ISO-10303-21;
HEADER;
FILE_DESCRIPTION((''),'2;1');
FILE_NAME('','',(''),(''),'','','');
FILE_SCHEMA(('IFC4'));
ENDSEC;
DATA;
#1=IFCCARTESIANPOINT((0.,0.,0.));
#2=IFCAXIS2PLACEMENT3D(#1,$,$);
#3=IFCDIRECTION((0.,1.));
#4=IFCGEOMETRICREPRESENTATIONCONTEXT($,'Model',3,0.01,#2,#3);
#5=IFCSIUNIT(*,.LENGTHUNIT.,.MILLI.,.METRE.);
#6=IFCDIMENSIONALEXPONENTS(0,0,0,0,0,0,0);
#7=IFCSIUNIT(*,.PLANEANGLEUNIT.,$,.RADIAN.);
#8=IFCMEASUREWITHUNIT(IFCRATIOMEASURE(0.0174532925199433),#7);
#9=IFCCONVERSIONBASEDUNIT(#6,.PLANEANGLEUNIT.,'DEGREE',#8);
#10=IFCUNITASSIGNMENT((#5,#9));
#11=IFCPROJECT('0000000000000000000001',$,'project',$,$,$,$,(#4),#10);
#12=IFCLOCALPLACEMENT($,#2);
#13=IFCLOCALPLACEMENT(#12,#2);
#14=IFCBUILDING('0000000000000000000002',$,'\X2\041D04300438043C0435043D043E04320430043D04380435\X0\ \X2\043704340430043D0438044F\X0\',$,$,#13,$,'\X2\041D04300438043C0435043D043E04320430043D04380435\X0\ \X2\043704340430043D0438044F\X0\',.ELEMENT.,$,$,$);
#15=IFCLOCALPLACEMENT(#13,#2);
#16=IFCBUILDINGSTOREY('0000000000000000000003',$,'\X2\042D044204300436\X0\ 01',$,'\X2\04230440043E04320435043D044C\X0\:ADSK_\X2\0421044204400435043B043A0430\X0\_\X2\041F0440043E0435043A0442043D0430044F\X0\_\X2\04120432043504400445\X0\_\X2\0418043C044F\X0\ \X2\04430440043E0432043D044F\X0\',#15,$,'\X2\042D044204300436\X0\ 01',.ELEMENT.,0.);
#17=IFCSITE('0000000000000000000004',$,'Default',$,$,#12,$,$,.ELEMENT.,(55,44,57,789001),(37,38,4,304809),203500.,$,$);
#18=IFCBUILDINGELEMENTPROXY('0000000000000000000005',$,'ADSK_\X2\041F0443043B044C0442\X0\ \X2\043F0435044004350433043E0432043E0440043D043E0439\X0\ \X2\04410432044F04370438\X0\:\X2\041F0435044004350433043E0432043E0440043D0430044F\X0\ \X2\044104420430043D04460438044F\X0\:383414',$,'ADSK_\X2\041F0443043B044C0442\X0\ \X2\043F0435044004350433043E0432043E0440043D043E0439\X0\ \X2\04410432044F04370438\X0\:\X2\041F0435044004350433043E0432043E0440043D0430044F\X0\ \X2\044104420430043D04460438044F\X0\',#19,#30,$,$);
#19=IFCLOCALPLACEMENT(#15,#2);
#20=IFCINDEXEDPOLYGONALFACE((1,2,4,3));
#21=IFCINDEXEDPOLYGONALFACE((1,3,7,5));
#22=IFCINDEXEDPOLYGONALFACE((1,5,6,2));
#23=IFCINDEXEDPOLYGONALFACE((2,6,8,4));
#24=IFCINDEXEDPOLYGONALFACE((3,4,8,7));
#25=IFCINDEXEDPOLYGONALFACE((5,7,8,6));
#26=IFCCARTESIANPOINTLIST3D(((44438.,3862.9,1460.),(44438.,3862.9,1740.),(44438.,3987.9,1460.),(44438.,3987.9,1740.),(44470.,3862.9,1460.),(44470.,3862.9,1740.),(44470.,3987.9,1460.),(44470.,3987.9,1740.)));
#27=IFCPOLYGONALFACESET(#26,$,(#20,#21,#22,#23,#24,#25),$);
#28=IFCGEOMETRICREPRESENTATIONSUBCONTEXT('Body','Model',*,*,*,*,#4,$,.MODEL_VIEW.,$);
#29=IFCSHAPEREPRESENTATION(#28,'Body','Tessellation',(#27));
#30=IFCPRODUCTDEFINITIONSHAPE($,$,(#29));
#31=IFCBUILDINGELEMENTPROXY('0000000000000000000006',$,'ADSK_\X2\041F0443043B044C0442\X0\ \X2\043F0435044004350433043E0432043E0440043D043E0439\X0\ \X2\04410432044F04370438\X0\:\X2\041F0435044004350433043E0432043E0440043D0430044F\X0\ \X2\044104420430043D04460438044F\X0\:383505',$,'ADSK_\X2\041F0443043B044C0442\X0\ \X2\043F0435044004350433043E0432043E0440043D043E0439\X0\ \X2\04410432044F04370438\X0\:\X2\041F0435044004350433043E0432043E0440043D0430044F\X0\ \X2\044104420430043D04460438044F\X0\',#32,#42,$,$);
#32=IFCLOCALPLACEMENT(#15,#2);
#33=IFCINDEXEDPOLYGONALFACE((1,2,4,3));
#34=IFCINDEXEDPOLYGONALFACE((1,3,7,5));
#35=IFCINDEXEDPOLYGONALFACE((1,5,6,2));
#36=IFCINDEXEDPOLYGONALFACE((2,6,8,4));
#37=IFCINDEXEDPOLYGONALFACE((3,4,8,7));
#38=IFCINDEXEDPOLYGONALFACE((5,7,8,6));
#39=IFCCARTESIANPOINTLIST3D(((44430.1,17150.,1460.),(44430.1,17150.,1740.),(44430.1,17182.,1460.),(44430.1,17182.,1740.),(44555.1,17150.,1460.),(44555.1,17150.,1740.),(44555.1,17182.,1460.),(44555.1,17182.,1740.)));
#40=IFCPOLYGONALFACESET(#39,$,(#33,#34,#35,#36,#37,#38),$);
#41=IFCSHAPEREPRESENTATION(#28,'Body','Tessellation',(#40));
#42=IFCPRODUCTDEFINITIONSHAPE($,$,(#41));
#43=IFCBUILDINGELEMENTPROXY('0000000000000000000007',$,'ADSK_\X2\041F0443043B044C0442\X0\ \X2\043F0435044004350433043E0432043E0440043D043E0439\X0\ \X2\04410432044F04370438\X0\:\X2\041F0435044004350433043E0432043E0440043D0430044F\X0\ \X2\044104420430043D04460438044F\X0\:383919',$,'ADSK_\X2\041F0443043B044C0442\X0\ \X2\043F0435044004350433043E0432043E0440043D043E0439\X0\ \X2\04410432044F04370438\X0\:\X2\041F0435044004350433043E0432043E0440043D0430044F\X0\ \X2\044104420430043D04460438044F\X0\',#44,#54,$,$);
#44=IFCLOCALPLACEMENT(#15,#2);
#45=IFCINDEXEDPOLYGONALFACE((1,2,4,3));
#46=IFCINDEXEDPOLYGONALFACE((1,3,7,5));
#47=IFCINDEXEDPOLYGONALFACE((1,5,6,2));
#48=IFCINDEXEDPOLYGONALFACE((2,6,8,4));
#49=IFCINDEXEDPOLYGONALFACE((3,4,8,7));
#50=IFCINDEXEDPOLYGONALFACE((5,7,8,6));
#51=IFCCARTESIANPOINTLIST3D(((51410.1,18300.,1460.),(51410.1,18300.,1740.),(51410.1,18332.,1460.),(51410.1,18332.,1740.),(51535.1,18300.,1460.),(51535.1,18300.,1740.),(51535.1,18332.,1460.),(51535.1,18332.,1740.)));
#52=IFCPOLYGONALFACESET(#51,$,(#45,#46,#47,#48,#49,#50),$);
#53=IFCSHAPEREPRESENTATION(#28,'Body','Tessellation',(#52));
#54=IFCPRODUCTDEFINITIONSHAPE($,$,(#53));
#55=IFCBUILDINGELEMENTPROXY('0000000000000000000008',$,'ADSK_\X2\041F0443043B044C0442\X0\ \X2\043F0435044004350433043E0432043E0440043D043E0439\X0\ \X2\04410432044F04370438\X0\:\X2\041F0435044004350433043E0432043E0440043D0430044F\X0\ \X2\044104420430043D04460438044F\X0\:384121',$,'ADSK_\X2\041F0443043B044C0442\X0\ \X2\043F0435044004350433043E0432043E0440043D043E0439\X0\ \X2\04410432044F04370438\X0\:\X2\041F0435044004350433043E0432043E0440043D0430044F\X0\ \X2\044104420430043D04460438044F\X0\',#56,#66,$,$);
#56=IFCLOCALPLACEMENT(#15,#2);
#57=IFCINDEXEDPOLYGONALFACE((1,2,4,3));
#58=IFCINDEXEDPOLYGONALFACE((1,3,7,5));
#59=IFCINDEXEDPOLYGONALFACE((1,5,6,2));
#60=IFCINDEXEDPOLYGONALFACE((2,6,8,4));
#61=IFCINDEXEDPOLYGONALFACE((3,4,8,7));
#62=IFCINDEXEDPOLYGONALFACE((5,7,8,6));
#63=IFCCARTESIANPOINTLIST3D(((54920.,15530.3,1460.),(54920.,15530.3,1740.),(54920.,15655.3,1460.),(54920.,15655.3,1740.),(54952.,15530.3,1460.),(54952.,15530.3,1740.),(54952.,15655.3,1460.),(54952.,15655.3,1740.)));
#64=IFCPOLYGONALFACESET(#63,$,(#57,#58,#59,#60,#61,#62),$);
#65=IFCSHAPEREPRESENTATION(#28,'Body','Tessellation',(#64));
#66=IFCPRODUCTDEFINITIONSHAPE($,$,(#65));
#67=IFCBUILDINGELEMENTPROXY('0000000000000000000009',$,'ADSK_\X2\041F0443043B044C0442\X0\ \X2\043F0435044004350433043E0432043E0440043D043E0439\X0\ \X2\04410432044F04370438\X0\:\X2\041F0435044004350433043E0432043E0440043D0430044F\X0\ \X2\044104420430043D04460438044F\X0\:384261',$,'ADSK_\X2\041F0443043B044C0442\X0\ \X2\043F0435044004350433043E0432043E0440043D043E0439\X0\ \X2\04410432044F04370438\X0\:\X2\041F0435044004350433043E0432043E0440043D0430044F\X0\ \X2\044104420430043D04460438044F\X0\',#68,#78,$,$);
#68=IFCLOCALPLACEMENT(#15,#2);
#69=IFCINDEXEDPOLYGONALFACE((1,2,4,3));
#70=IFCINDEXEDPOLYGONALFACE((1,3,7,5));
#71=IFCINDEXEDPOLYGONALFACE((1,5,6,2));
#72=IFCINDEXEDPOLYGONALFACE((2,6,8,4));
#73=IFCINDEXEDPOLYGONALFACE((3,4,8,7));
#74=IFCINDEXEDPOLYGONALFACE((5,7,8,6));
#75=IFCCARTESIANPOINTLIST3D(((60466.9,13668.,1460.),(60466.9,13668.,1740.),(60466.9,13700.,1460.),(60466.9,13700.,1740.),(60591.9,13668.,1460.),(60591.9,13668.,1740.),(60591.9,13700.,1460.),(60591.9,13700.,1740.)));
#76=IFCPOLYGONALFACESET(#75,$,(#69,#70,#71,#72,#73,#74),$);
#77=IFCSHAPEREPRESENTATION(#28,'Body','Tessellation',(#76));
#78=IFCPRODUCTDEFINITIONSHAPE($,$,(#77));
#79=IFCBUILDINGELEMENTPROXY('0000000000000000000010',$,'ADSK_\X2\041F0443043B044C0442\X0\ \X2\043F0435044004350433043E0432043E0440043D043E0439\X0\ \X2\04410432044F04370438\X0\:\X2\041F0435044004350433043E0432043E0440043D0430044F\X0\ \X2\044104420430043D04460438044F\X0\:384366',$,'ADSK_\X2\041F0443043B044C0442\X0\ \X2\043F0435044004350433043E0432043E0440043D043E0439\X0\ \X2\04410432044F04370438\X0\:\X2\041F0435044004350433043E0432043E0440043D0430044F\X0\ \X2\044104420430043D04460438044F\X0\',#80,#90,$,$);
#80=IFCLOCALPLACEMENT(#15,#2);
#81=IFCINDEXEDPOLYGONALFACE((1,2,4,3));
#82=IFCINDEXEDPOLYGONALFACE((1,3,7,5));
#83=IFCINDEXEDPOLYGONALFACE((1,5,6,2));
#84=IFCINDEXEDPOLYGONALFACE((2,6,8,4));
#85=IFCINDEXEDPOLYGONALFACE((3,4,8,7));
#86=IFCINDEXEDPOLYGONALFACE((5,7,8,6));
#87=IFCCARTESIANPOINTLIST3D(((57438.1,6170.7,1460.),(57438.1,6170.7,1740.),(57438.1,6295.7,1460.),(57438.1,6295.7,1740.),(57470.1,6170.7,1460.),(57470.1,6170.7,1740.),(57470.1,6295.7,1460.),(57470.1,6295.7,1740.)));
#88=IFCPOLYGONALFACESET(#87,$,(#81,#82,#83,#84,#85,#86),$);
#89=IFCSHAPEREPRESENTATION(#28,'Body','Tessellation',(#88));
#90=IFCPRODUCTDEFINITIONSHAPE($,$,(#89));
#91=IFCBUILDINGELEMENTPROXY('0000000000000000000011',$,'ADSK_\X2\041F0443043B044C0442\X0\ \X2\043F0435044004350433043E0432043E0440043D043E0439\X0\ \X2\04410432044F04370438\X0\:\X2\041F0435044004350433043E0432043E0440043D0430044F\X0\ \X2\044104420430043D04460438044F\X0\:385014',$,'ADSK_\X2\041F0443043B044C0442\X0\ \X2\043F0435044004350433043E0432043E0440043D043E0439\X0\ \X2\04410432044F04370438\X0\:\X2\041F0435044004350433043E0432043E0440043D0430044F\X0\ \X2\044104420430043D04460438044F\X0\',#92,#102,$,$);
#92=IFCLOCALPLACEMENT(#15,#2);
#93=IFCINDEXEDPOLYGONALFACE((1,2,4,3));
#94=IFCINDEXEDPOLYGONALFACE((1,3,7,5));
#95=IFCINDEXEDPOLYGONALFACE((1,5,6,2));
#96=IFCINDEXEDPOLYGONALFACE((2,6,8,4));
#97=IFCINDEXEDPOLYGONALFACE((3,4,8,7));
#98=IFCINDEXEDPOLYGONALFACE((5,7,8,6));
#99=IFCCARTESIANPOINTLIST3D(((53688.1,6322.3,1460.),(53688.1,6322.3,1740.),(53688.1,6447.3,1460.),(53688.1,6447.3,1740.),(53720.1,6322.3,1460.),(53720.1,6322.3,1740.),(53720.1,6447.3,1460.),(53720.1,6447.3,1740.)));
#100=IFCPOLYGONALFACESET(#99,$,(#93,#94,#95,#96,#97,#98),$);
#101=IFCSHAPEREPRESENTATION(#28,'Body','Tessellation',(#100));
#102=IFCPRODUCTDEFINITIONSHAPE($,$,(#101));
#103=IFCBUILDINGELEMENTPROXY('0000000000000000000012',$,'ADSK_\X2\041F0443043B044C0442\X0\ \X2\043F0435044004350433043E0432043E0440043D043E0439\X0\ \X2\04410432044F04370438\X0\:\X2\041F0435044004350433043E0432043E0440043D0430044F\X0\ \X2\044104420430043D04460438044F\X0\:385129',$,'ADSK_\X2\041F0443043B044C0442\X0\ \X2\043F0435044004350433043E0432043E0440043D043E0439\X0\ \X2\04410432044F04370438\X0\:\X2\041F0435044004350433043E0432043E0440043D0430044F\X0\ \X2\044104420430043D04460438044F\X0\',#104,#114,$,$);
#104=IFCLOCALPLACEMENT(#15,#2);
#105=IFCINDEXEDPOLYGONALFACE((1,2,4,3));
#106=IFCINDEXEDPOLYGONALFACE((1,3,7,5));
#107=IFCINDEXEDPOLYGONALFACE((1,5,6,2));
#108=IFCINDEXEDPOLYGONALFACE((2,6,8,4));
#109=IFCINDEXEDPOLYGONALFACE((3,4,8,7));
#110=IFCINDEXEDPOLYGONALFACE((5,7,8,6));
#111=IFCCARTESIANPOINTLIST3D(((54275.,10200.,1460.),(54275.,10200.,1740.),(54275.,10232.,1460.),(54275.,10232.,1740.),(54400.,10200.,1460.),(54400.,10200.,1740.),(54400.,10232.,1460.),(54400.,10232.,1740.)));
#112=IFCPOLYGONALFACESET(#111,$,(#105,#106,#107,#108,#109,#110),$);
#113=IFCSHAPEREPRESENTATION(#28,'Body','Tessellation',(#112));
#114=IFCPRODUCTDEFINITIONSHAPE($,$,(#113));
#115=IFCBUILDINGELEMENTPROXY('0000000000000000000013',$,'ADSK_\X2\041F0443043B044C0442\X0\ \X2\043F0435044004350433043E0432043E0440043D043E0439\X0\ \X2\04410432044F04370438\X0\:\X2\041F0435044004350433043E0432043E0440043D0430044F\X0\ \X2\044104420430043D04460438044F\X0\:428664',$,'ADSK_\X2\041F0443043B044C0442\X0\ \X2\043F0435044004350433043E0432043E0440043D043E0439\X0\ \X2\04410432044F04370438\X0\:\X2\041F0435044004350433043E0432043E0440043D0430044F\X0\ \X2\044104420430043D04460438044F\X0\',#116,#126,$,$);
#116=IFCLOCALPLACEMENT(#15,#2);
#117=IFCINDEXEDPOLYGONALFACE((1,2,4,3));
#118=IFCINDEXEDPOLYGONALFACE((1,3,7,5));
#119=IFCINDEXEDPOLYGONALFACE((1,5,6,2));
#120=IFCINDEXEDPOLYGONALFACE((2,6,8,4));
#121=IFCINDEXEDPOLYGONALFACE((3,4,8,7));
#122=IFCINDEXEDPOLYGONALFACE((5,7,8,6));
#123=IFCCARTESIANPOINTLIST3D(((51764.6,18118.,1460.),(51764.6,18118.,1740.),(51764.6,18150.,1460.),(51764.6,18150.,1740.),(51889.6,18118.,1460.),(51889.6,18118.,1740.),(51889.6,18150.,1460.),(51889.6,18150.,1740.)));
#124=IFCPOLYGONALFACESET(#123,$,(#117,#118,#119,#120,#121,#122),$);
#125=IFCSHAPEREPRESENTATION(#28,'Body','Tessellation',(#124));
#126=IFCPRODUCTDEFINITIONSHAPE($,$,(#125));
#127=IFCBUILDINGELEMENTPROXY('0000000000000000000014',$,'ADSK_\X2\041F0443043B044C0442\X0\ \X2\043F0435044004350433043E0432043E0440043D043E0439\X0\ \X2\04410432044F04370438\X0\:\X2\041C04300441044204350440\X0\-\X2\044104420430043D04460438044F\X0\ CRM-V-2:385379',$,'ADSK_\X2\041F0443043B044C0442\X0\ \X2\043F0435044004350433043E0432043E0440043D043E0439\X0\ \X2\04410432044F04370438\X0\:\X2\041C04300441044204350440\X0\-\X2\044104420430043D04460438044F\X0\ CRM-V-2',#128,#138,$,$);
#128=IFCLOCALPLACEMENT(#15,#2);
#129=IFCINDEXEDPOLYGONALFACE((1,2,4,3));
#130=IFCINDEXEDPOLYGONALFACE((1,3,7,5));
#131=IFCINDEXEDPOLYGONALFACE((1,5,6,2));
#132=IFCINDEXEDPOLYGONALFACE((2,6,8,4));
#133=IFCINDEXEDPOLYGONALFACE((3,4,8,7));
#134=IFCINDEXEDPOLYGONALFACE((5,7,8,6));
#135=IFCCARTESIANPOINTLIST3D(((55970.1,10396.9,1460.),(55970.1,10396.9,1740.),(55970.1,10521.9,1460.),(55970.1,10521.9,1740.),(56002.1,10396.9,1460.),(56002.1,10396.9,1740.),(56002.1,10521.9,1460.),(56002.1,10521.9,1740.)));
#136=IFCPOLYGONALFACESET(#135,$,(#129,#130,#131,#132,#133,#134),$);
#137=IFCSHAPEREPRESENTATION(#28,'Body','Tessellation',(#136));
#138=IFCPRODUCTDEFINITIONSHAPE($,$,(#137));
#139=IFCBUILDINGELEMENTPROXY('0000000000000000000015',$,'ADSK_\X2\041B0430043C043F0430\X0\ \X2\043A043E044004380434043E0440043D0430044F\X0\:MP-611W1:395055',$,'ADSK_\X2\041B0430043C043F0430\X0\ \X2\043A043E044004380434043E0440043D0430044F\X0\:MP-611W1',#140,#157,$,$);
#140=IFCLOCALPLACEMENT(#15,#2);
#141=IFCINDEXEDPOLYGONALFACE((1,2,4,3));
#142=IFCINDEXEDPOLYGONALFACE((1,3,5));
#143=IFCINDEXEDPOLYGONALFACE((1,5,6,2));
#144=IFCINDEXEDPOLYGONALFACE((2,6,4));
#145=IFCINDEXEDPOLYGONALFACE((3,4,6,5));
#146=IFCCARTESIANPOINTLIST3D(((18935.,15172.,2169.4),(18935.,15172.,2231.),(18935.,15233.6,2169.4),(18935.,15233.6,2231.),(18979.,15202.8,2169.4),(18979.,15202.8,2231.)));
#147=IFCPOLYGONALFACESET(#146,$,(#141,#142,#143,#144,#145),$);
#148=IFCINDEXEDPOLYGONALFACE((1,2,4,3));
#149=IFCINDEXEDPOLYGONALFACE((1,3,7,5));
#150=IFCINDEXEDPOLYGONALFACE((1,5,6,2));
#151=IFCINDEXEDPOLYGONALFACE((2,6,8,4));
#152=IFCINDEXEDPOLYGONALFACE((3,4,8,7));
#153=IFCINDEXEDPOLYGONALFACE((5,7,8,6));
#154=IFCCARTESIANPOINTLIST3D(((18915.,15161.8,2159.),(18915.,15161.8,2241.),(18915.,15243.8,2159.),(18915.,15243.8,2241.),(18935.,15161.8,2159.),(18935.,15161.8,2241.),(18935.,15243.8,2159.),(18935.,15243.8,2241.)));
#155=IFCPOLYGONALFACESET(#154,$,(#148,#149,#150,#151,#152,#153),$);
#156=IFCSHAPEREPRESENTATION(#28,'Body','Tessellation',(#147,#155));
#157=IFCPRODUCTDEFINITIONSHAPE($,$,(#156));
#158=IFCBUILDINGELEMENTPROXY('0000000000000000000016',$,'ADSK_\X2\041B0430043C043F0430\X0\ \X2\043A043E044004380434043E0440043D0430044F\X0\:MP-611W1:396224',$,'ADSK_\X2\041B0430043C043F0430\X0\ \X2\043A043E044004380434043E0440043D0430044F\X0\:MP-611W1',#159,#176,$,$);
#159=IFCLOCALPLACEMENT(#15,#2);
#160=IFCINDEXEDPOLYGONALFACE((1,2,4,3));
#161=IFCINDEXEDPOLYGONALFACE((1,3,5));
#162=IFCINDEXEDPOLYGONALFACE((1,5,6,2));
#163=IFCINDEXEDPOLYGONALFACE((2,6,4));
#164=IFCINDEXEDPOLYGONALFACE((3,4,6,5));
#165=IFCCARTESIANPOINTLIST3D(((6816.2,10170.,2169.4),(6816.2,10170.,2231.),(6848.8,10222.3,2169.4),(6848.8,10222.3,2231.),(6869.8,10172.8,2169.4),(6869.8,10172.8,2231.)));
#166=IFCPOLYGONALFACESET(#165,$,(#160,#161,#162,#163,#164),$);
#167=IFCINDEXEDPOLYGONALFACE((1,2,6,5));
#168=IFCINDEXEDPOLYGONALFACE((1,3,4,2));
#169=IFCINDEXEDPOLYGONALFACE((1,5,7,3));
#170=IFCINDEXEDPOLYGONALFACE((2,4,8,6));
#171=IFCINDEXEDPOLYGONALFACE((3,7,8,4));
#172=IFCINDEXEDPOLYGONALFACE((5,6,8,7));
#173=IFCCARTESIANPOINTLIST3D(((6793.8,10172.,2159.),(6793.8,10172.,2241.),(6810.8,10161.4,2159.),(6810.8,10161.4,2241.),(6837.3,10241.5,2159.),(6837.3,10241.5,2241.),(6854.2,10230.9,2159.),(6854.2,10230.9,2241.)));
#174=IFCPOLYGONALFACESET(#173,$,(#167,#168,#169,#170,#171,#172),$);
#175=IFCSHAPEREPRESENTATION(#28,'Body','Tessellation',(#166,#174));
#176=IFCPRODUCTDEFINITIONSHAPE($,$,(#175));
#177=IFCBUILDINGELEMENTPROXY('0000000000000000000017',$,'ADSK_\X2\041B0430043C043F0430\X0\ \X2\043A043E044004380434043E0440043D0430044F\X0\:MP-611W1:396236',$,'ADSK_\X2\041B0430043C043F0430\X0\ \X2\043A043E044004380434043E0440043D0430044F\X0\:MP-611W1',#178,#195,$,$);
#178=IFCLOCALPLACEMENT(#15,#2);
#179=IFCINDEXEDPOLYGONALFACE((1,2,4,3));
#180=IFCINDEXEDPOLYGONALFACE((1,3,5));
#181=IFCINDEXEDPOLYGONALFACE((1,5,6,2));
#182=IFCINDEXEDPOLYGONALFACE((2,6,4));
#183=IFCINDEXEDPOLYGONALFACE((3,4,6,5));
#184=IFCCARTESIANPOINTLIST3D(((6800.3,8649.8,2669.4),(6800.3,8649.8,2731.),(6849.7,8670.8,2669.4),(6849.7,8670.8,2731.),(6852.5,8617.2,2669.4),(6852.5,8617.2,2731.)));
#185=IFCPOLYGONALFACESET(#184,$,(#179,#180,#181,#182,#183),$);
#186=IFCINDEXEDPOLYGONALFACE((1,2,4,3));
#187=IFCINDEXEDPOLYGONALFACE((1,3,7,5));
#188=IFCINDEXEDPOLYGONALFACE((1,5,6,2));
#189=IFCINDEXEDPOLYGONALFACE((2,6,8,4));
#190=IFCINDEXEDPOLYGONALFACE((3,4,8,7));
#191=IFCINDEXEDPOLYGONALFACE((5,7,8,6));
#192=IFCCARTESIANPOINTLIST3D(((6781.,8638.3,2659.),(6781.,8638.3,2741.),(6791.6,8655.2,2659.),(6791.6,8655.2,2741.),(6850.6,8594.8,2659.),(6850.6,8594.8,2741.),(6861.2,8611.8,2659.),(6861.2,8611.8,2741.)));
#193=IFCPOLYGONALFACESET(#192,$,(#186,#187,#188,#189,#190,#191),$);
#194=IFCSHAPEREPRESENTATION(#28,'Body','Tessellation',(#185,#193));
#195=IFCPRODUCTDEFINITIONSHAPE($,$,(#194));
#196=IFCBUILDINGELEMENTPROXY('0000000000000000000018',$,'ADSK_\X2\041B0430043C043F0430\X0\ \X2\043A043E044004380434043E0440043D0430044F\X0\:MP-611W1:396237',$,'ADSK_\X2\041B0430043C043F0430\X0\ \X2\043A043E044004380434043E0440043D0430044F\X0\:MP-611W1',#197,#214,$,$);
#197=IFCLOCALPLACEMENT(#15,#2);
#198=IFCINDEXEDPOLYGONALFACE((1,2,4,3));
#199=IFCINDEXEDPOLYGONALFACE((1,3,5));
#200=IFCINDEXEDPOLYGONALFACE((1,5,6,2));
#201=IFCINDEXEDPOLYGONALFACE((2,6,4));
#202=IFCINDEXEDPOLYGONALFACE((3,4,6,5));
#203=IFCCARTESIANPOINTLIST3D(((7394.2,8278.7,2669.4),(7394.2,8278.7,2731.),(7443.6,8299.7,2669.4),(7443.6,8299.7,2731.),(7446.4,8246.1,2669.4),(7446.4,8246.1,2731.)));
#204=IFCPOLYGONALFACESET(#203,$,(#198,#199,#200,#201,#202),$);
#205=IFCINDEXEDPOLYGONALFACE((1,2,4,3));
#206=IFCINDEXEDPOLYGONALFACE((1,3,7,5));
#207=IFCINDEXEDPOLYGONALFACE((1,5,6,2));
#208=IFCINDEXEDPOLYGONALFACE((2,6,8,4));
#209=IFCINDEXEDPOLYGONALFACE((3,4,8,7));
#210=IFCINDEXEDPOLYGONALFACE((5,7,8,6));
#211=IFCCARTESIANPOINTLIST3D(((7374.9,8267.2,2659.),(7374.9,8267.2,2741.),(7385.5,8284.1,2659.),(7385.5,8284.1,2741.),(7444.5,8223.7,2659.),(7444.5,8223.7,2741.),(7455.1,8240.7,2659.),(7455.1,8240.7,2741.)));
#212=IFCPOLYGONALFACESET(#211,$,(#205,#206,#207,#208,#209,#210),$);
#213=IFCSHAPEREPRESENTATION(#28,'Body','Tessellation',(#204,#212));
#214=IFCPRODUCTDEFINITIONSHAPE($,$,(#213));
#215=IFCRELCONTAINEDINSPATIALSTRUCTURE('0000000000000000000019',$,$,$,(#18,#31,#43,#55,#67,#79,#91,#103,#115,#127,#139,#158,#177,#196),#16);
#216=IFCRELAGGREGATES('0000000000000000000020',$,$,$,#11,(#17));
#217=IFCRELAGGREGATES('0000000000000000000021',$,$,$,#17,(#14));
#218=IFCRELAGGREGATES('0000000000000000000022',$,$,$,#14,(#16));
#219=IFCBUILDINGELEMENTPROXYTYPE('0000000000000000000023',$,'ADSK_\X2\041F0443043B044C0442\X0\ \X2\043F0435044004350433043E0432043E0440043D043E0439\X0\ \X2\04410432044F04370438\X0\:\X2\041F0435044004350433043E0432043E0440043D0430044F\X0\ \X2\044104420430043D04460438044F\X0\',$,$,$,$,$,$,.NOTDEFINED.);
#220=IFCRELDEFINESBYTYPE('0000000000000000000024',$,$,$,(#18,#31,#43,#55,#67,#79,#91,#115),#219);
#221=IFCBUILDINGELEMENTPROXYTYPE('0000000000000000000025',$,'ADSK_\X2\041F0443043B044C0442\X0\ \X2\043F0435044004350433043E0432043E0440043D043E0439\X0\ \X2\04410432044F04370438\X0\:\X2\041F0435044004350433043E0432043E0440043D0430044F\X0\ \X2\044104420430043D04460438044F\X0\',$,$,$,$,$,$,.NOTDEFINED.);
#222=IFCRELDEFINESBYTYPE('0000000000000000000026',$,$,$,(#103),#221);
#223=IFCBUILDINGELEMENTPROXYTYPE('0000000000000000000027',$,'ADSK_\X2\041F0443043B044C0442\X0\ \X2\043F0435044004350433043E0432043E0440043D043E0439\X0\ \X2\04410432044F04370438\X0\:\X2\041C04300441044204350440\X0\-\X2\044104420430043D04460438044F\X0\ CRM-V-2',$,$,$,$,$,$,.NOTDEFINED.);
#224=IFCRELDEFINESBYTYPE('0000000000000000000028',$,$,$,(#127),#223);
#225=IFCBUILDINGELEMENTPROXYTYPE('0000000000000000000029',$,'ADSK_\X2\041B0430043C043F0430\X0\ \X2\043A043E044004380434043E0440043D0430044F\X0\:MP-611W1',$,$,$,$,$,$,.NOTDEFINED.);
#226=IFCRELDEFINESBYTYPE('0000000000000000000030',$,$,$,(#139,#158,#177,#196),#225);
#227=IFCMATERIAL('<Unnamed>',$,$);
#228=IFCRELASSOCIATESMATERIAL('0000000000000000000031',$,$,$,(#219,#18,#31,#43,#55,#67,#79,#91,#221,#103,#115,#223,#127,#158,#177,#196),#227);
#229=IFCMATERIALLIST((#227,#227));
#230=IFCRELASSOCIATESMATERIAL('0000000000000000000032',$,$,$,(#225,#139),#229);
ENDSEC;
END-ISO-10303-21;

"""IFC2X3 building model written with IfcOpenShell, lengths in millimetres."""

from ifc_helpers import new_model, entity, si_unit, converted_unit, direction, frame, origin, origin_2d_with_axis, place, context, subcontext, project, spatial, polyline, rectangle, outline, extrude, source, transform, mapped, material, material_list, type_object, type_shapes, element, save


model = new_model("IFC2X3")

# Units and contexts
model_context = context("Model", 3, precision=0.01, world=origin(), true_north=direction((0.0, 1.0)))
body_context = subcontext(model_context, "Body", "Model", "MODEL_VIEW")
ifc_project = project(units=[si_unit("LENGTHUNIT", "METRE", prefix="MILLI"), converted_unit("PLANEANGLEUNIT", "DEGREE", entity("IfcRatioMeasure", 0.0174532925199433), si_unit("PLANEANGLEUNIT", "RADIAN"), dimensions=[0, 0, 0, 0, 0, 0, 0])], contexts=[model_context])

# Site, building, storey
site_placement = place(None, origin())
site = spatial("IfcSite", under=ifc_project, at=site_placement, Name="Default", CompositionType="ELEMENT", RefLatitude=(55, 44, 57, 789001), RefLongitude=(37, 38, 4, 304809), RefElevation=203500.0)
building_placement = place(site_placement, origin())
building = spatial("IfcBuilding", under=site, at=building_placement, Name="Наименование здания", LongName="Наименование здания", CompositionType="ELEMENT")
storey_placement = place(building_placement, origin())
storey = spatial("IfcBuildingStorey", under=building, at=storey_placement, Name="Этаж 01", ObjectType="Уровень:ADSK_Стрелка_Проектная_Вверх_Имя уровня", LongName="Этаж 01", CompositionType="ELEMENT", Elevation=0.0)

# Building element proxies
ifc_material_1 = material(Name="<Unnamed>")
building_element_proxy_type_1 = type_object("IfcBuildingElementProxyType", Name="ADSK_Пульт переговорной связи:Переговорная станция", PredefinedType="NOTDEFINED", material=ifc_material_1)
shared_shape_1 = source(origin(), body_context, "Body", "SweptSolid", [
    extrude(rectangle(XDim=125.0, YDim=32.0, at=origin_2d_with_axis()), frame((0.0, 16.0, -140.0), z_axis=(0.0, 0.0, 1.0), x_axis=(-1.0, 0.0, 0.0)), (0.0, 0.0, 1.0), 280.0),
])
type_shapes(building_element_proxy_type_1, [shared_shape_1])
for number, where, z_axis, x_axis, name in (
    (1, (44438.0, 3925.4, 1600.0), (0.0, 0.0, 1.0), (0.0, -1.0, 0.0), "ADSK_Пульт переговорной связи:Переговорная станция:383414"),
    (2, (44492.6, 17182.0, 1600.0), (0.0, 0.0, 1.0), (-1.0, 0.0, 0.0), "ADSK_Пульт переговорной связи:Переговорная станция:383505"),
    (3, (51472.6, 18332.0, 1600.0), (0.0, 0.0, 1.0), (-1.0, 0.0, 0.0), "ADSK_Пульт переговорной связи:Переговорная станция:383919"),
    (4, (54952.0, 15592.8, 1600.0), (0.0, 0.0, 1.0), (0.0, 1.0, 0.0), "ADSK_Пульт переговорной связи:Переговорная станция:384121"),
):
    element("IfcBuildingElementProxy", number, at=place(storey_placement, frame(where, z_axis=z_axis, x_axis=x_axis)), inside=storey, type_object=building_element_proxy_type_1, material=ifc_material_1, Name=name, ObjectType="ADSK_Пульт переговорной связи:Переговорная станция", context=body_context, shape_type="MappedRepresentation", body=[
        mapped(shared_shape_1, transform((0.0, 0.0, 0.0), scale=1.0)),
    ])
proxy_1_placement = place(storey_placement, frame((60529.4, 13668.0, 1600.0)))
element("IfcBuildingElementProxy", 5, at=proxy_1_placement, inside=storey, type_object=building_element_proxy_type_1, material=ifc_material_1, Name="ADSK_Пульт переговорной связи:Переговорная станция:384261", ObjectType="ADSK_Пульт переговорной связи:Переговорная станция", context=body_context, shape_type="MappedRepresentation", body=[
    mapped(shared_shape_1, transform((0.0, 0.0, 0.0), scale=1.0)),
])
for number, where, z_axis, x_axis, name in (
    (6, (57438.1, 6233.2, 1600.0), (0.0, 0.0, 1.0), (0.0, -1.0, 0.0), "ADSK_Пульт переговорной связи:Переговорная станция:384366"),
    (7, (53688.1, 6384.8, 1600.0), (0.0, 0.0, 1.0), (0.0, -1.0, 0.0), "ADSK_Пульт переговорной связи:Переговорная станция:385014"),
):
    element("IfcBuildingElementProxy", number, at=place(storey_placement, frame(where, z_axis=z_axis, x_axis=x_axis)), inside=storey, type_object=building_element_proxy_type_1, material=ifc_material_1, Name=name, ObjectType="ADSK_Пульт переговорной связи:Переговорная станция", context=body_context, shape_type="MappedRepresentation", body=[
        mapped(shared_shape_1, transform((0.0, 0.0, 0.0), scale=1.0)),
    ])
building_element_proxy_type_2 = type_object("IfcBuildingElementProxyType", Name="ADSK_Пульт переговорной связи:Переговорная станция", PredefinedType="NOTDEFINED", material=ifc_material_1)
type_shapes(building_element_proxy_type_2, [shared_shape_1])
proxy_2_placement = place(storey_placement, frame((54337.5, 10232.0, 1600.0), z_axis=(0.0, 0.0, 1.0), x_axis=(-1.0, 0.0, 0.0)))
element("IfcBuildingElementProxy", 8, at=proxy_2_placement, inside=storey, type_object=building_element_proxy_type_2, material=ifc_material_1, Name="ADSK_Пульт переговорной связи:Переговорная станция:385129", ObjectType="ADSK_Пульт переговорной связи:Переговорная станция", context=body_context, shape_type="MappedRepresentation", body=[
    mapped(shared_shape_1, transform((0.0, 0.0, 0.0), scale=1.0)),
])
proxy_3_placement = place(storey_placement, frame((51827.1, 18118.0, 1600.0)))
element("IfcBuildingElementProxy", 9, at=proxy_3_placement, inside=storey, type_object=building_element_proxy_type_1, material=ifc_material_1, Name="ADSK_Пульт переговорной связи:Переговорная станция:428664", ObjectType="ADSK_Пульт переговорной связи:Переговорная станция", context=body_context, shape_type="MappedRepresentation", body=[
    mapped(shared_shape_1, transform((0.0, 0.0, 0.0), scale=1.0)),
])
building_element_proxy_type_3 = type_object("IfcBuildingElementProxyType", Name="ADSK_Пульт переговорной связи:Мастер-станция CRM-V-2", PredefinedType="NOTDEFINED", material=ifc_material_1)
shared_shape_2 = source(origin(), body_context, "Body", "SweptSolid", [
    extrude(rectangle(XDim=125.0, YDim=32.0, at=origin_2d_with_axis()), frame((0.0, 16.0, -140.0), z_axis=(0.0, 0.0, 1.0), x_axis=(-1.0, 0.0, 0.0)), (0.0, 0.0, 1.0), 280.0),
])
type_shapes(building_element_proxy_type_3, [shared_shape_2])
proxy_4_placement = place(storey_placement, frame((56002.1, 10459.4, 1600.0), z_axis=(0.0, 0.0, 1.0), x_axis=(0.0, 1.0, 0.0)))
element("IfcBuildingElementProxy", 10, at=proxy_4_placement, inside=storey, type_object=building_element_proxy_type_3, material=ifc_material_1, Name="ADSK_Пульт переговорной связи:Мастер-станция CRM-V-2:385379", ObjectType="ADSK_Пульт переговорной связи:Мастер-станция CRM-V-2", context=body_context, shape_type="MappedRepresentation", body=[
    mapped(shared_shape_2, transform((0.0, 0.0, 0.0), scale=1.0)),
])
ifc_material_list_1 = material_list([ifc_material_1, ifc_material_1])
building_element_proxy_type_4 = type_object("IfcBuildingElementProxyType", Name="ADSK_Лампа коридорная:MP-611W1", PredefinedType="NOTDEFINED", material=ifc_material_list_1)
shared_shape_3 = source(origin(), body_context, "Body", "SweptSolid", [
    extrude(outline(polyline([(-30.8, -14.7), (30.8, -14.7), (0.0, 29.3), (-30.8, -14.7)])), frame((0.0, -2.7, -30.6), z_axis=(0.0, 0.0, 1.0), x_axis=(-1.0, 0.0, 0.0)), (0.0, 0.0, 1.0), 61.6),
    extrude(rectangle(XDim=82.0, YDim=20.0, at=origin_2d_with_axis()), frame((0.0, 22.0, -41.0), z_axis=(0.0, 0.0, 1.0), x_axis=(-1.0, 0.0, 0.0)), (0.0, 0.0, 1.0), 82.0),
])
type_shapes(building_element_proxy_type_4, [shared_shape_3])
proxy_5_placement = place(storey_placement, frame((18947.0, 15202.8, 2200.0), z_axis=(0.0, 0.0, 1.0), x_axis=(0.0, 1.0, 0.0)))
element("IfcBuildingElementProxy", 11, at=proxy_5_placement, inside=storey, type_object=building_element_proxy_type_4, material=ifc_material_list_1, Name="ADSK_Лампа коридорная:MP-611W1:395055", ObjectType="ADSK_Лампа коридорная:MP-611W1", context=body_context, shape_type="MappedRepresentation", body=[
    mapped(shared_shape_3, transform((0.0, 0.0, 0.0), scale=1.0)),
])
for number, where, z_axis, x_axis, name in (
    (12, (6842.7, 10189.8, 2200.0), (0.0, 0.0, 1.0), (0.529919, 0.848048, 0.0), "ADSK_Лампа коридорная:MP-611W1:396224"),
    (13, (6832.8, 8643.7, 2700.0), (0.0, 0.0, 1.0), (-0.848053, 0.529912, 0.0), "ADSK_Лампа коридорная:MP-611W1:396236"),
    (14, (7426.6, 8272.6, 2700.0), (0.0, 0.0, 1.0), (-0.848053, 0.529912, 0.0), "ADSK_Лампа коридорная:MP-611W1:396237"),
):
    element("IfcBuildingElementProxy", number, at=place(storey_placement, frame(where, z_axis=z_axis, x_axis=x_axis)), inside=storey, type_object=building_element_proxy_type_4, material=ifc_material_1, Name=name, ObjectType="ADSK_Лампа коридорная:MP-611W1", context=body_context, shape_type="MappedRepresentation", body=[
        mapped(shared_shape_3, transform((0.0, 0.0, 0.0), scale=1.0)),
    ])

save(model, "model.ifc")
